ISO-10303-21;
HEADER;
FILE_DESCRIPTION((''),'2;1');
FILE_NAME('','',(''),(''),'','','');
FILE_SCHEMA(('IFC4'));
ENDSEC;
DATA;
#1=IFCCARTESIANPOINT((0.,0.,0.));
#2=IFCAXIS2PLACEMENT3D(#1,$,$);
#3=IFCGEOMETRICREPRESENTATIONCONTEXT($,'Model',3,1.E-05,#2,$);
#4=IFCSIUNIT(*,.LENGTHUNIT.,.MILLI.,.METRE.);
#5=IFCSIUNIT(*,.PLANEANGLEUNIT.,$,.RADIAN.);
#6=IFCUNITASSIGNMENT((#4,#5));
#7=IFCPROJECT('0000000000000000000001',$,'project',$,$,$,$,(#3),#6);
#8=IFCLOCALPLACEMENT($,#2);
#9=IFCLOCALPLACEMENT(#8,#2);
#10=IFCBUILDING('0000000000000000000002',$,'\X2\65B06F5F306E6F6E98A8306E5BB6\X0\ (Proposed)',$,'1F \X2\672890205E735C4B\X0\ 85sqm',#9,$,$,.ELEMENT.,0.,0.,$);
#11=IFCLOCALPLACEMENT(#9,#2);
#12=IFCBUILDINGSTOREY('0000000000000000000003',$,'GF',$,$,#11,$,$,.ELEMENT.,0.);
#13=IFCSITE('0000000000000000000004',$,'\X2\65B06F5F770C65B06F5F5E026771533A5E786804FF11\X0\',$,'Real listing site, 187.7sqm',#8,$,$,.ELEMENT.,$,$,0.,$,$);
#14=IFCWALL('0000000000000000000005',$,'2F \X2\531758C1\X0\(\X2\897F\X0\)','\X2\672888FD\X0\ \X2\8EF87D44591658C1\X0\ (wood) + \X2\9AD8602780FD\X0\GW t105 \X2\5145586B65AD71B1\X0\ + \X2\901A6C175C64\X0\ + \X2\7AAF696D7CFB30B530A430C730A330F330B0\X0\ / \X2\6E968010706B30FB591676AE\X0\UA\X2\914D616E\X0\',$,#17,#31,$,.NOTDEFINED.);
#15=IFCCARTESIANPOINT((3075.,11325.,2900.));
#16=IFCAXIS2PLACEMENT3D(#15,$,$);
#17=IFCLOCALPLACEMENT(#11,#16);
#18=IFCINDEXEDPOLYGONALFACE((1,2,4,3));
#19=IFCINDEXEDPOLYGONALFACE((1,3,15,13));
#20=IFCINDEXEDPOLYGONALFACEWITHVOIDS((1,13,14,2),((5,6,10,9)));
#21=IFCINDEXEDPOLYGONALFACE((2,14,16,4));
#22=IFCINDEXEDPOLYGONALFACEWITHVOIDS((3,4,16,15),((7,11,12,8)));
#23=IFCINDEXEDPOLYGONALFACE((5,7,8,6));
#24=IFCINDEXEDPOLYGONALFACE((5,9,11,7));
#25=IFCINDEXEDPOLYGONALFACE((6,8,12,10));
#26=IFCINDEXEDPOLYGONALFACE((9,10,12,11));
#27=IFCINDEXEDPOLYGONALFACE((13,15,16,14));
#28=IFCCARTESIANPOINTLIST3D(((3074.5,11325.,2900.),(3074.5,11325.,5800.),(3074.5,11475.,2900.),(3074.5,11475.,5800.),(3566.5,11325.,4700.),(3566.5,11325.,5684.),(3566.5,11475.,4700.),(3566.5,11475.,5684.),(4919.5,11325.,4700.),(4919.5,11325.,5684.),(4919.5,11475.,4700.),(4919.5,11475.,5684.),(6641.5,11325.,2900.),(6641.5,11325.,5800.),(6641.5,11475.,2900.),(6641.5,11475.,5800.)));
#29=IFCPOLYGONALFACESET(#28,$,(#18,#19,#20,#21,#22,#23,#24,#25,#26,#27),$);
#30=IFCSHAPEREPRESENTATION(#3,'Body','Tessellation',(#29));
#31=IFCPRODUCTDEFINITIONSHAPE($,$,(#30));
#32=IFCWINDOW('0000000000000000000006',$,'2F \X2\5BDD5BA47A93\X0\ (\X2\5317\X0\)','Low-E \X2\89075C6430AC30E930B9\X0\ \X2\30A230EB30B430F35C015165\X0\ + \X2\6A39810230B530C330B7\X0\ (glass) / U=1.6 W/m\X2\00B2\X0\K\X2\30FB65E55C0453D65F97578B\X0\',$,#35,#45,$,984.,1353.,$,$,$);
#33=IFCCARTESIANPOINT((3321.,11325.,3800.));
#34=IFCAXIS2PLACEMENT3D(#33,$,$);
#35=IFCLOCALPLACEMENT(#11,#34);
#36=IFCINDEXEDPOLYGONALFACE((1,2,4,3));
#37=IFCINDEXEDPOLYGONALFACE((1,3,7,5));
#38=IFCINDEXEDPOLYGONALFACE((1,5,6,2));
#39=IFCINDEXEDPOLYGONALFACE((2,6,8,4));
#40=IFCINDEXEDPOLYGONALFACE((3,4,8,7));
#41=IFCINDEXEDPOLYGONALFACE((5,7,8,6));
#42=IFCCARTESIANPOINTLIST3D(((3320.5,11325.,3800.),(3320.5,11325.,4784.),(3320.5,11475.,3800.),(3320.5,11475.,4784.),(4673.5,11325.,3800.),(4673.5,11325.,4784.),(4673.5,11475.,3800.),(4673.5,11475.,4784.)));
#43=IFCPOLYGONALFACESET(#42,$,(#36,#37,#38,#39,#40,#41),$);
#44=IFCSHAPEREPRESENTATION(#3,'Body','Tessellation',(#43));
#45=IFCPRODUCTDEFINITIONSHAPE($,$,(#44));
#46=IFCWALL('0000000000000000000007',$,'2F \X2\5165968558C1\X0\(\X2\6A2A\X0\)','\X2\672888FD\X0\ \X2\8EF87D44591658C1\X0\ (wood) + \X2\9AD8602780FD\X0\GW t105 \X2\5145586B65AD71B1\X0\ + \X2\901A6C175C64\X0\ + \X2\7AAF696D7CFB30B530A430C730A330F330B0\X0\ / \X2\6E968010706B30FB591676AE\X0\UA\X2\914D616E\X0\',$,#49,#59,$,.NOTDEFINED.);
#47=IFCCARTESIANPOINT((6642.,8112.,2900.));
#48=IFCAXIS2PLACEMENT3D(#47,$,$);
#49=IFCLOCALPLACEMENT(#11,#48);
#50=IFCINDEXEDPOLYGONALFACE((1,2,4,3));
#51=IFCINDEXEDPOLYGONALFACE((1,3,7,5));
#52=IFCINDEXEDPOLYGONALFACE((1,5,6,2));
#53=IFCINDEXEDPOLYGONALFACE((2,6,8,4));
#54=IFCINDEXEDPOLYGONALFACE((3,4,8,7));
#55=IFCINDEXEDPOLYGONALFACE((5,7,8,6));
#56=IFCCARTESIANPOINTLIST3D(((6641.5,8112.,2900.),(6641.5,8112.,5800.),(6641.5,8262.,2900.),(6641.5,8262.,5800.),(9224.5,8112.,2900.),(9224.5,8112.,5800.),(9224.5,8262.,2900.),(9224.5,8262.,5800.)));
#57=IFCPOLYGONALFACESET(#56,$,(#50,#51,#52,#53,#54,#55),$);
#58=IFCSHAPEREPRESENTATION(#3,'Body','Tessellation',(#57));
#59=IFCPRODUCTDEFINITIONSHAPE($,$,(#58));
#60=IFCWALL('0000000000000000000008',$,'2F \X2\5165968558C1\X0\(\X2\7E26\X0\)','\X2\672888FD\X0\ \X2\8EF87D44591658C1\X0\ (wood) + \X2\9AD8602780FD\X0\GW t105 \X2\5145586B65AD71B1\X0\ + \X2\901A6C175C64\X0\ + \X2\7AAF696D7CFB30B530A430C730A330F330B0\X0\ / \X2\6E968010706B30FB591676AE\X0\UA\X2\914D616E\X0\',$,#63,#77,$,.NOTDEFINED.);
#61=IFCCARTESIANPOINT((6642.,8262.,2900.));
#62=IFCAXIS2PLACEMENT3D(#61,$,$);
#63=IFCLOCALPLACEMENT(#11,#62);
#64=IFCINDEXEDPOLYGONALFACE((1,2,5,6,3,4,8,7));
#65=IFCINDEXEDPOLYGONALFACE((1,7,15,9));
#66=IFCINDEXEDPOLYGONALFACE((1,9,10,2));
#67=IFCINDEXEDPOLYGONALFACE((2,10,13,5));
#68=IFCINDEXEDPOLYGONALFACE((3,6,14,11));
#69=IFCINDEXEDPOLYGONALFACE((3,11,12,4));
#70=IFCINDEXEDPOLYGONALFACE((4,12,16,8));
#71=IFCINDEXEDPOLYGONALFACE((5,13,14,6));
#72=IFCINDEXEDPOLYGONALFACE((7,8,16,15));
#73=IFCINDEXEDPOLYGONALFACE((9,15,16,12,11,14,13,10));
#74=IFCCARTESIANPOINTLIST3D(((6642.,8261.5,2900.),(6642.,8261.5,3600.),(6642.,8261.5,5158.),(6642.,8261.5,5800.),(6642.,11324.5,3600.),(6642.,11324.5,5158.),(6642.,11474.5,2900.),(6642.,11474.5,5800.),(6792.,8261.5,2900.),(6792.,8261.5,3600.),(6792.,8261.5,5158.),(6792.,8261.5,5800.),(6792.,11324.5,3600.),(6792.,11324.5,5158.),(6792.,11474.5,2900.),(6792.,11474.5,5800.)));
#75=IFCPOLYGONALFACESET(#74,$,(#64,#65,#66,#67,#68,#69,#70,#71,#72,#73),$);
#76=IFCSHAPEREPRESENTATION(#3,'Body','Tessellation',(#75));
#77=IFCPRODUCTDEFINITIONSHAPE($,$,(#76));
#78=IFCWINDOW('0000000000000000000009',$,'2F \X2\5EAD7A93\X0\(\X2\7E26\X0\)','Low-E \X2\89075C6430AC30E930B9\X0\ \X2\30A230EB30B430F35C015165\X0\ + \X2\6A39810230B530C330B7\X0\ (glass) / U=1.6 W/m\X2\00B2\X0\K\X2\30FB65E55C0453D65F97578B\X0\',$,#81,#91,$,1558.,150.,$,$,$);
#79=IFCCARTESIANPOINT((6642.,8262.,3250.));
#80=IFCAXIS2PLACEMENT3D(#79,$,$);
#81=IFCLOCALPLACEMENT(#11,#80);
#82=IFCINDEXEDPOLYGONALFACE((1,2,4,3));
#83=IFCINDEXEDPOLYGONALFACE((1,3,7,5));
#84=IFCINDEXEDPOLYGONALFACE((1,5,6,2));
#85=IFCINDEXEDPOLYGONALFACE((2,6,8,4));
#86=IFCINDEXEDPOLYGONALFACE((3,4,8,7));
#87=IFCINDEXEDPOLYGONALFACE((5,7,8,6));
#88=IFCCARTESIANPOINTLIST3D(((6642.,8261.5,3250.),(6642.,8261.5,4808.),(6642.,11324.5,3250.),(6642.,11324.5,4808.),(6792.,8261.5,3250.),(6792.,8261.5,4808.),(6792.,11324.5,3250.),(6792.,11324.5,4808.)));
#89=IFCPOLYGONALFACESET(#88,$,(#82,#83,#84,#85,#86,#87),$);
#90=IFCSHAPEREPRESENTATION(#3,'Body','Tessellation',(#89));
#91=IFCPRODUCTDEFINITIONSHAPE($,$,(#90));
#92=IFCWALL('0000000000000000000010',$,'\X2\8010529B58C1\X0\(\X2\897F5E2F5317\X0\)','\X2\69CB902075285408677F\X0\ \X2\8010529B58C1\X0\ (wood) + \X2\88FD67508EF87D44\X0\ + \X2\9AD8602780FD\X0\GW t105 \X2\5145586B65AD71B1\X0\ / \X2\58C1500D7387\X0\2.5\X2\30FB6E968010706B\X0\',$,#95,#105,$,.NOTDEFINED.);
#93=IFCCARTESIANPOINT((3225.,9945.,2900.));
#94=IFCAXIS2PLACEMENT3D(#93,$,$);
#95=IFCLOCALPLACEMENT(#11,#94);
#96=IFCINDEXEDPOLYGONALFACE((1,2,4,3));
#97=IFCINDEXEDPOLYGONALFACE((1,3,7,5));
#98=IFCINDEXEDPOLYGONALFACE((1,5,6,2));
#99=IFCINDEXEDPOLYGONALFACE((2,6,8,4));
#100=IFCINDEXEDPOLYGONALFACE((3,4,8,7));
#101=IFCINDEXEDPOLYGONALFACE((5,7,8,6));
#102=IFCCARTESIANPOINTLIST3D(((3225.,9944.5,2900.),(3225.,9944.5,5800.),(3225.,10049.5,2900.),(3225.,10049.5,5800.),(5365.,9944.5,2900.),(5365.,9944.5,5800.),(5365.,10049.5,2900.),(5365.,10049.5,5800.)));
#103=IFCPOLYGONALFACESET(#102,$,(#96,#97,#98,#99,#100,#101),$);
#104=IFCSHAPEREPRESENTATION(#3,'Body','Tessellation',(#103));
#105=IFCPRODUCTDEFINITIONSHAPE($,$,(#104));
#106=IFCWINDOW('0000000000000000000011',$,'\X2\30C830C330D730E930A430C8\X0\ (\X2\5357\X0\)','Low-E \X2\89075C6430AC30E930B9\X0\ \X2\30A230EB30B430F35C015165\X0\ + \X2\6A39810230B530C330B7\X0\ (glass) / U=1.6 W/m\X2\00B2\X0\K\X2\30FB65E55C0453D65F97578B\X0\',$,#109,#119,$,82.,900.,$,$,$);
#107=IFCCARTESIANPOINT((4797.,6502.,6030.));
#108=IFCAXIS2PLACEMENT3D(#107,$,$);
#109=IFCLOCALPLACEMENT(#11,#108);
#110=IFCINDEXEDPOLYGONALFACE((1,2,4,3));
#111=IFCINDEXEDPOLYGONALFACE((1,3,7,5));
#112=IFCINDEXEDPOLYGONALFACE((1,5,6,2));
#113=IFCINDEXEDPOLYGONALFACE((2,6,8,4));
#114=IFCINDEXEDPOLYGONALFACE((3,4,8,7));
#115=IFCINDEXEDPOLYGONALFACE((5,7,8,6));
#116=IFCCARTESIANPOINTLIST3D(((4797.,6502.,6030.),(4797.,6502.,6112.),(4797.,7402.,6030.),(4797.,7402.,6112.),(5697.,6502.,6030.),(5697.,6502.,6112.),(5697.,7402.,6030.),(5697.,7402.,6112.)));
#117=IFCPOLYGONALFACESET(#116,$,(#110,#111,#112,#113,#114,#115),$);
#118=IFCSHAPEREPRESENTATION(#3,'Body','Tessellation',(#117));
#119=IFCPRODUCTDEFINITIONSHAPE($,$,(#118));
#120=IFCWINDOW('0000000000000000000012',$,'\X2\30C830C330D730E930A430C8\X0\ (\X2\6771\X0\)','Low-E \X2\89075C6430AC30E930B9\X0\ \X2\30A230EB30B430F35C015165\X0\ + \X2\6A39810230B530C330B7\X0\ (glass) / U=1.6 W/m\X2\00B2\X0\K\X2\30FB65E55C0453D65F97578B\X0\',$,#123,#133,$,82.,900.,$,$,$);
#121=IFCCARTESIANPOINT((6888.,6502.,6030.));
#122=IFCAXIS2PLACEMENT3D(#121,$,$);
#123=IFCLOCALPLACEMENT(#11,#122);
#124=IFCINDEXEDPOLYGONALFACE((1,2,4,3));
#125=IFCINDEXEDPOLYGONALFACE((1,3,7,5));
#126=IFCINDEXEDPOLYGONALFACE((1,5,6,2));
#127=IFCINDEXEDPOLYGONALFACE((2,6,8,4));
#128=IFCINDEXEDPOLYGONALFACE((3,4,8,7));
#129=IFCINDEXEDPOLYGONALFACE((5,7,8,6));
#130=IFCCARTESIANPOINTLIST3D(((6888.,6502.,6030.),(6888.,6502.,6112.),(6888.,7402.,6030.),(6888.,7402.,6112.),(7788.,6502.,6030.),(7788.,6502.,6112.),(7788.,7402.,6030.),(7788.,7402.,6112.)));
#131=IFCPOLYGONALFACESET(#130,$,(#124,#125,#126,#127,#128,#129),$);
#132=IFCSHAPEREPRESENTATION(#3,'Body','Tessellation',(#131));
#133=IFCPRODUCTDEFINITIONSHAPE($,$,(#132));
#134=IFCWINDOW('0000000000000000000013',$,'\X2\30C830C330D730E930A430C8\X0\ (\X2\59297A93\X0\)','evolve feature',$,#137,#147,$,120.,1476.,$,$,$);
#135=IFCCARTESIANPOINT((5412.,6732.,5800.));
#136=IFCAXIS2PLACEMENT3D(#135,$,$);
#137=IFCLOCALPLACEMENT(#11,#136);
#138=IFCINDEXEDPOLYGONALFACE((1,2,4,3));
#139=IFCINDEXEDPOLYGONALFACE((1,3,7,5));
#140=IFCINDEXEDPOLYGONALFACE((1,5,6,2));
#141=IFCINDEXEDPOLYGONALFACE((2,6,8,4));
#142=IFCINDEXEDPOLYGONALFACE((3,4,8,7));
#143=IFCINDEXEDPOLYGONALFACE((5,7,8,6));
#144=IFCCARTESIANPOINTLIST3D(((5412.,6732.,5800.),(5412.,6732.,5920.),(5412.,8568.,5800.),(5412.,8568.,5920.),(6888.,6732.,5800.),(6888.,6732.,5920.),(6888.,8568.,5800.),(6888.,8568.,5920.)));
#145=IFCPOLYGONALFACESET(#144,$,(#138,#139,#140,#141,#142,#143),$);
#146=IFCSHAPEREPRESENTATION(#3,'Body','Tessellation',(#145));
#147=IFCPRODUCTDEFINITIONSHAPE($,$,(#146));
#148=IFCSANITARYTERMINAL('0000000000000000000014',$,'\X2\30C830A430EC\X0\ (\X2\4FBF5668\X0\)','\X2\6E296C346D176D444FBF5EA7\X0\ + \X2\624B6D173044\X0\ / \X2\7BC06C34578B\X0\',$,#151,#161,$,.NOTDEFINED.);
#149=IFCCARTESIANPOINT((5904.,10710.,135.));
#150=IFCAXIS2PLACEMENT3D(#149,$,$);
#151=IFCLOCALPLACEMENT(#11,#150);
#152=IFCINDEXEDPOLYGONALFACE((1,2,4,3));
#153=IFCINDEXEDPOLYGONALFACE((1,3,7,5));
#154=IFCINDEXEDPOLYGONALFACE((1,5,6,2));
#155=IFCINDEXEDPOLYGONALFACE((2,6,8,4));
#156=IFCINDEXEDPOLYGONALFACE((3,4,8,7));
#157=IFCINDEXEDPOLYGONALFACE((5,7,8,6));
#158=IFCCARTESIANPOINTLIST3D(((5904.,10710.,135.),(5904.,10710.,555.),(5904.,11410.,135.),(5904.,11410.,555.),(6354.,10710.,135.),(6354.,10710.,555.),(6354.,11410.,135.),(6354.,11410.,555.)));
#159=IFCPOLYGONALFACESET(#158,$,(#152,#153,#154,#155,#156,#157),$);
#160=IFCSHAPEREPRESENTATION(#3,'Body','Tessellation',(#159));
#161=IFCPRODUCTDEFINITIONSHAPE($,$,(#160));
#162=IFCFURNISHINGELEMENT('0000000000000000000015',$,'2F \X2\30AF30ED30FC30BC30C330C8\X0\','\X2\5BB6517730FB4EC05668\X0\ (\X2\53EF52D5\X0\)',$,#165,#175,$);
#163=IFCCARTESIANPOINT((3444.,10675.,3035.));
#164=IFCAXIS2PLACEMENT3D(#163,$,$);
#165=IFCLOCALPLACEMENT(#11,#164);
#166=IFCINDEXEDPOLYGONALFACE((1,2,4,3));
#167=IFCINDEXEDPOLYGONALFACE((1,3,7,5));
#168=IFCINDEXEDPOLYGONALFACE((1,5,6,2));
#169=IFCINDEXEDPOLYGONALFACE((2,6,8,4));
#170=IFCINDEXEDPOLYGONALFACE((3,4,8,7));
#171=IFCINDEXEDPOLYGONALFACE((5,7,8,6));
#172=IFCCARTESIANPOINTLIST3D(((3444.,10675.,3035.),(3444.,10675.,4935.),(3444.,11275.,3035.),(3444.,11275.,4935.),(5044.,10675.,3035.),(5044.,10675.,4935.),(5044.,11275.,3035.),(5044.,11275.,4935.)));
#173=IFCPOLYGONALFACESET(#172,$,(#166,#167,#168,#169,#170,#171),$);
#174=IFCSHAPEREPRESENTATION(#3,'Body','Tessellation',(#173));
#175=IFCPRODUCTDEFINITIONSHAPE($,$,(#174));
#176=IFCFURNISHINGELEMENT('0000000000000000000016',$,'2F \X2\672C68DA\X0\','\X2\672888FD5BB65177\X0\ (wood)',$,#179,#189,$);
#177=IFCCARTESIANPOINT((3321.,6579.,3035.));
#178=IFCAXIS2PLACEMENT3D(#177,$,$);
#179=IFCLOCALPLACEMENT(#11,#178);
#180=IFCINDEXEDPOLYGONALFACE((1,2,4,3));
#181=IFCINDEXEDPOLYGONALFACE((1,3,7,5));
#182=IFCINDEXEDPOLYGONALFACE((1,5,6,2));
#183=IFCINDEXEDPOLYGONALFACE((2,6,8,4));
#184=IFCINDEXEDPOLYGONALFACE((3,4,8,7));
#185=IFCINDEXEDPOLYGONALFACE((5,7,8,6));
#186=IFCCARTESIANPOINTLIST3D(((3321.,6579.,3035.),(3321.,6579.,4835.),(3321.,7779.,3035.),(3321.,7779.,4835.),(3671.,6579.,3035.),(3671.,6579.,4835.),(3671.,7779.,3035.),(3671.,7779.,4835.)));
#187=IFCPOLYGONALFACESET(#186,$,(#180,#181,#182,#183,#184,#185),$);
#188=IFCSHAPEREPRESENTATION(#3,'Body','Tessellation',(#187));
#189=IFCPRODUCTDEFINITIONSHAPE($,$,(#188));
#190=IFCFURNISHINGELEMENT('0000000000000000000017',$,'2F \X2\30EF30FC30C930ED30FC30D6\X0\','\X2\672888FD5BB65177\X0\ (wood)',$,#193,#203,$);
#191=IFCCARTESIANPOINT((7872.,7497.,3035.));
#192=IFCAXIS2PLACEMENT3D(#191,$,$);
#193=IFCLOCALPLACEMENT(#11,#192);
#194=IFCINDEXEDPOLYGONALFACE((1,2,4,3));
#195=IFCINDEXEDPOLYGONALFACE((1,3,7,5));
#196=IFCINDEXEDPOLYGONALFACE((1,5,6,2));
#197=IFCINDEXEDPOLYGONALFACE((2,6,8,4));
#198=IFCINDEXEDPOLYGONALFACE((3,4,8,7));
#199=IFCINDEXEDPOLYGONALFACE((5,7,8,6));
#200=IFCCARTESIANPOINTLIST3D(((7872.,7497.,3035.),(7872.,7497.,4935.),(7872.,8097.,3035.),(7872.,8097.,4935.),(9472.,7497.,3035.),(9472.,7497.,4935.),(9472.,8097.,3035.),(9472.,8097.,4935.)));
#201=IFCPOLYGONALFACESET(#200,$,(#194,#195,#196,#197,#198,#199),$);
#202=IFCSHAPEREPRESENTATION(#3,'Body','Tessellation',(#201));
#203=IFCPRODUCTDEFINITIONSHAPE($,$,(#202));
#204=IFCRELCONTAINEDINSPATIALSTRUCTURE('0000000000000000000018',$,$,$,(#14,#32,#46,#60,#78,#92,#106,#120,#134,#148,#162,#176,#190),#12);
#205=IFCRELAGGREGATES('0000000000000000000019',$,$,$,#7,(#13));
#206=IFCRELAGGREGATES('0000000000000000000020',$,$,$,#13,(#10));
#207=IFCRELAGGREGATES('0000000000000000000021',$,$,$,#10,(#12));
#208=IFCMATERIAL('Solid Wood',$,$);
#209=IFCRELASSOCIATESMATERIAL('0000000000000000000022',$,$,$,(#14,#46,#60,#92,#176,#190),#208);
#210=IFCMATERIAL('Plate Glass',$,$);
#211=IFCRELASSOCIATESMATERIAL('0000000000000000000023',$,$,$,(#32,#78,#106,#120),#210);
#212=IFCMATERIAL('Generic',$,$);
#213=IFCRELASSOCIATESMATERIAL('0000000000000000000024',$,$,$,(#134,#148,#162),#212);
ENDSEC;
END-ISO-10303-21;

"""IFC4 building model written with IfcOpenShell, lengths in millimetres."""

from ifc_helpers import new_model, si_unit, frame, frame_2d, origin, place, context, project, spatial, rectangle, extrude, material, element, fill, save


model = new_model("IFC4")

# Units and contexts
model_context = context("Model", 3, precision=1e-05, world=origin())
ifc_project = project(units=[si_unit("LENGTHUNIT", "METRE", prefix="MILLI"), si_unit("PLANEANGLEUNIT", "RADIAN")], contexts=[model_context])

# Site, building, storey
site_placement = place(None, origin())
site = spatial("IfcSite", under=ifc_project, at=site_placement, Name="新潟県新潟市東区幸栄１", ObjectType="Real listing site, 187.7sqm", CompositionType="ELEMENT", RefElevation=0.0)
building_placement = place(site_placement, origin())
building = spatial("IfcBuilding", under=site, at=building_placement, Name="新潟の潮風の家 (Proposed)", ObjectType="1F 木造平屋 85sqm", CompositionType="ELEMENT", ElevationOfRefHeight=0.0, ElevationOfTerrain=0.0)
storey_placement = place(building_placement, origin())
storey = spatial("IfcBuildingStorey", under=building, at=storey_placement, Name="GF", CompositionType="ELEMENT", Elevation=0.0)

# Shared definitions
ifc_material_1 = material(Name="Solid Wood")

# Wall, opening, window
wall_1_placement = place(storey_placement, frame((3075.0, 11325.0, 2900.0)))
wall_1 = element("IfcWall", 1, at=wall_1_placement, inside=storey, material=ifc_material_1, Name="2F 北壁(西)", Description="木製 軸組外壁 (wood) + 高性能GW t105 充填断熱 + 通気層 + 窯業系サイディング / 準耐火・外皮UA配慮", PredefinedType="NOTDEFINED", context=model_context, shape_type="SweptSolid", body=[
    extrude(rectangle(XDim=3567.0, YDim=150.0, at=frame_2d((1783.0, 75.0))), frame((3075.0, 11325.0, 2900.0)), (0.0, 0.0, 1.0), 2900.0),
])
opening_1_placement = place(storey_placement, frame((3321.0, 11325.0, 3800.0)))
opening_1 = element("IfcOpeningElement", 2, at=opening_1_placement, cuts=wall_1, PredefinedType="NOTDEFINED", context=model_context, shape_type="SweptSolid", body=[
    extrude(rectangle(XDim=1353.0, YDim=150.0, at=frame_2d((676.0, 75.0))), frame((3321.0, 11325.0, 3800.0)), (0.0, 0.0, 1.0), 984.0),
])
ifc_material_2 = material(Name="Plate Glass")
window_1_placement = place(storey_placement, frame((3321.0, 11325.0, 3800.0)))
window_1 = element("IfcWindow", 3, at=window_1_placement, inside=storey, material=ifc_material_2, Name="2F 寝室窓 (北)", Description="Low-E 複層ガラス アルゴン封入 + 樹脂サッシ (glass) / U=1.6 W/m²K・日射取得型", OverallHeight=984.0, OverallWidth=1353.0, context=model_context, shape_type="SweptSolid", body=[
    extrude(rectangle(XDim=1353.0, YDim=150.0, at=frame_2d((676.0, 75.0))), frame((3321.0, 11325.0, 3800.0)), (0.0, 0.0, 1.0), 984.0),
])
fill(opening_1, window_1)

# Wall
wall_2_placement = place(storey_placement, frame((6642.0, 8112.0, 2900.0)))
element("IfcWall", 4, at=wall_2_placement, inside=storey, material=ifc_material_1, Name="2F 入隅壁(横)", Description="木製 軸組外壁 (wood) + 高性能GW t105 充填断熱 + 通気層 + 窯業系サイディング / 準耐火・外皮UA配慮", PredefinedType="NOTDEFINED", context=model_context, shape_type="SweptSolid", body=[
    extrude(rectangle(XDim=2583.0, YDim=150.0, at=frame_2d((1291.0, 75.0))), frame((6642.0, 8112.0, 2900.0)), (0.0, 0.0, 1.0), 2900.0),
])

# Wall, opening, window
wall_3_placement = place(storey_placement, frame((6642.0, 8262.0, 2900.0)))
wall_3 = element("IfcWall", 5, at=wall_3_placement, inside=storey, material=ifc_material_1, Name="2F 入隅壁(縦)", Description="木製 軸組外壁 (wood) + 高性能GW t105 充填断熱 + 通気層 + 窯業系サイディング / 準耐火・外皮UA配慮", PredefinedType="NOTDEFINED", context=model_context, shape_type="SweptSolid", body=[
    extrude(rectangle(XDim=150.0, YDim=3213.0, at=frame_2d((75.0, 1606.0))), frame((6642.0, 8262.0, 2900.0)), (0.0, 0.0, 1.0), 2900.0),
])
opening_2_placement = place(storey_placement, frame((6642.0, 8262.0, 3250.0)))
opening_2 = element("IfcOpeningElement", 6, at=opening_2_placement, cuts=wall_3, PredefinedType="NOTDEFINED", context=model_context, shape_type="SweptSolid", body=[
    extrude(rectangle(XDim=150.0, YDim=3063.0, at=frame_2d((75.0, 1531.0))), frame((6642.0, 8262.0, 3250.0)), (0.0, 0.0, 1.0), 1558.0),
])
window_2_placement = place(storey_placement, frame((6642.0, 8262.0, 3250.0)))
window_2 = element("IfcWindow", 7, at=window_2_placement, inside=storey, material=ifc_material_2, Name="2F 庭窓(縦)", Description="Low-E 複層ガラス アルゴン封入 + 樹脂サッシ (glass) / U=1.6 W/m²K・日射取得型", OverallHeight=1558.0, OverallWidth=150.0, context=model_context, shape_type="SweptSolid", body=[
    extrude(rectangle(XDim=150.0, YDim=3063.0, at=frame_2d((75.0, 1531.0))), frame((6642.0, 8262.0, 3250.0)), (0.0, 0.0, 1.0), 1558.0),
])
fill(opening_2, window_2)

# Wall
wall_4_placement = place(storey_placement, frame((3225.0, 9945.0, 2900.0)))
element("IfcWall", 8, at=wall_4_placement, inside=storey, material=ifc_material_1, Name="耐力壁(西帯北)", Description="構造用合板 耐力壁 (wood) + 製材軸組 + 高性能GW t105 充填断熱 / 壁倍率2.5・準耐火", PredefinedType="NOTDEFINED", context=model_context, shape_type="SweptSolid", body=[
    extrude(rectangle(XDim=2140.0, YDim=105.0, at=frame_2d((1070.0, 52.0))), frame((3225.0, 9945.0, 2900.0)), (0.0, 0.0, 1.0), 2900.0),
])

# Windows
window_3_placement = place(storey_placement, frame((4797.0, 6502.0, 6030.0)))
element("IfcWindow", 9, at=window_3_placement, inside=storey, material=ifc_material_2, Name="トップライト (南)", Description="Low-E 複層ガラス アルゴン封入 + 樹脂サッシ (glass) / U=1.6 W/m²K・日射取得型", OverallHeight=82.0, OverallWidth=900.0, context=model_context, shape_type="SweptSolid", body=[
    extrude(rectangle(XDim=900.0, YDim=900.0, at=frame_2d((450.0, 450.0))), frame((4797.0, 6502.0, 6030.0)), (0.0, 0.0, 1.0), 82.0),
])
window_4_placement = place(storey_placement, frame((6888.0, 6502.0, 6030.0)))
element("IfcWindow", 10, at=window_4_placement, inside=storey, material=ifc_material_2, Name="トップライト (東)", Description="Low-E 複層ガラス アルゴン封入 + 樹脂サッシ (glass) / U=1.6 W/m²K・日射取得型", OverallHeight=82.0, OverallWidth=900.0, context=model_context, shape_type="SweptSolid", body=[
    extrude(rectangle(XDim=900.0, YDim=900.0, at=frame_2d((450.0, 450.0))), frame((6888.0, 6502.0, 6030.0)), (0.0, 0.0, 1.0), 82.0),
])
ifc_material_3 = material(Name="Generic")
window_5_placement = place(storey_placement, frame((5412.0, 6732.0, 5800.0)))
element("IfcWindow", 11, at=window_5_placement, inside=storey, material=ifc_material_3, Name="トップライト (天窓)", Description="evolve feature", OverallHeight=120.0, OverallWidth=1476.0, context=model_context, shape_type="SweptSolid", body=[
    extrude(rectangle(XDim=1476.0, YDim=1836.0, at=frame_2d((738.0, 918.0))), frame((5412.0, 6732.0, 5800.0)), (0.0, 0.0, 1.0), 120.0),
])

# Sanitary terminal
sanitary_terminal_placement = place(storey_placement, frame((5904.0, 10710.0, 135.0)))
element("IfcSanitaryTerminal", 12, at=sanitary_terminal_placement, inside=storey, material=ifc_material_3, Name="トイレ (便器)", Description="温水洗浄便座 + 手洗い / 節水型", PredefinedType="NOTDEFINED", context=model_context, shape_type="SweptSolid", body=[
    extrude(rectangle(XDim=450.0, YDim=700.0, at=frame_2d((225.0, 350.0))), frame((5904.0, 10710.0, 135.0)), (0.0, 0.0, 1.0), 420.0),
])

# Furnishing elements
furnishing_1_placement = place(storey_placement, frame((3444.0, 10675.0, 3035.0)))
element("IfcFurnishingElement", 13, at=furnishing_1_placement, inside=storey, material=ifc_material_3, Name="2F クローゼット", Description="家具・什器 (可動)", context=model_context, shape_type="SweptSolid", body=[
    extrude(rectangle(XDim=1600.0, YDim=600.0, at=frame_2d((800.0, 300.0))), frame((3444.0, 10675.0, 3035.0)), (0.0, 0.0, 1.0), 1900.0),
])
furnishing_2_placement = place(storey_placement, frame((3321.0, 6579.0, 3035.0)))
element("IfcFurnishingElement", 14, at=furnishing_2_placement, inside=storey, material=ifc_material_1, Name="2F 本棚", Description="木製家具 (wood)", context=model_context, shape_type="SweptSolid", body=[
    extrude(rectangle(XDim=350.0, YDim=1200.0, at=frame_2d((175.0, 600.0))), frame((3321.0, 6579.0, 3035.0)), (0.0, 0.0, 1.0), 1800.0),
])
furnishing_3_placement = place(storey_placement, frame((7872.0, 7497.0, 3035.0)))
element("IfcFurnishingElement", 15, at=furnishing_3_placement, inside=storey, material=ifc_material_1, Name="2F ワードローブ", Description="木製家具 (wood)", context=model_context, shape_type="SweptSolid", body=[
    extrude(rectangle(XDim=1600.0, YDim=600.0, at=frame_2d((800.0, 300.0))), frame((7872.0, 7497.0, 3035.0)), (0.0, 0.0, 1.0), 1900.0),
])

save(model, "model.ifc")
